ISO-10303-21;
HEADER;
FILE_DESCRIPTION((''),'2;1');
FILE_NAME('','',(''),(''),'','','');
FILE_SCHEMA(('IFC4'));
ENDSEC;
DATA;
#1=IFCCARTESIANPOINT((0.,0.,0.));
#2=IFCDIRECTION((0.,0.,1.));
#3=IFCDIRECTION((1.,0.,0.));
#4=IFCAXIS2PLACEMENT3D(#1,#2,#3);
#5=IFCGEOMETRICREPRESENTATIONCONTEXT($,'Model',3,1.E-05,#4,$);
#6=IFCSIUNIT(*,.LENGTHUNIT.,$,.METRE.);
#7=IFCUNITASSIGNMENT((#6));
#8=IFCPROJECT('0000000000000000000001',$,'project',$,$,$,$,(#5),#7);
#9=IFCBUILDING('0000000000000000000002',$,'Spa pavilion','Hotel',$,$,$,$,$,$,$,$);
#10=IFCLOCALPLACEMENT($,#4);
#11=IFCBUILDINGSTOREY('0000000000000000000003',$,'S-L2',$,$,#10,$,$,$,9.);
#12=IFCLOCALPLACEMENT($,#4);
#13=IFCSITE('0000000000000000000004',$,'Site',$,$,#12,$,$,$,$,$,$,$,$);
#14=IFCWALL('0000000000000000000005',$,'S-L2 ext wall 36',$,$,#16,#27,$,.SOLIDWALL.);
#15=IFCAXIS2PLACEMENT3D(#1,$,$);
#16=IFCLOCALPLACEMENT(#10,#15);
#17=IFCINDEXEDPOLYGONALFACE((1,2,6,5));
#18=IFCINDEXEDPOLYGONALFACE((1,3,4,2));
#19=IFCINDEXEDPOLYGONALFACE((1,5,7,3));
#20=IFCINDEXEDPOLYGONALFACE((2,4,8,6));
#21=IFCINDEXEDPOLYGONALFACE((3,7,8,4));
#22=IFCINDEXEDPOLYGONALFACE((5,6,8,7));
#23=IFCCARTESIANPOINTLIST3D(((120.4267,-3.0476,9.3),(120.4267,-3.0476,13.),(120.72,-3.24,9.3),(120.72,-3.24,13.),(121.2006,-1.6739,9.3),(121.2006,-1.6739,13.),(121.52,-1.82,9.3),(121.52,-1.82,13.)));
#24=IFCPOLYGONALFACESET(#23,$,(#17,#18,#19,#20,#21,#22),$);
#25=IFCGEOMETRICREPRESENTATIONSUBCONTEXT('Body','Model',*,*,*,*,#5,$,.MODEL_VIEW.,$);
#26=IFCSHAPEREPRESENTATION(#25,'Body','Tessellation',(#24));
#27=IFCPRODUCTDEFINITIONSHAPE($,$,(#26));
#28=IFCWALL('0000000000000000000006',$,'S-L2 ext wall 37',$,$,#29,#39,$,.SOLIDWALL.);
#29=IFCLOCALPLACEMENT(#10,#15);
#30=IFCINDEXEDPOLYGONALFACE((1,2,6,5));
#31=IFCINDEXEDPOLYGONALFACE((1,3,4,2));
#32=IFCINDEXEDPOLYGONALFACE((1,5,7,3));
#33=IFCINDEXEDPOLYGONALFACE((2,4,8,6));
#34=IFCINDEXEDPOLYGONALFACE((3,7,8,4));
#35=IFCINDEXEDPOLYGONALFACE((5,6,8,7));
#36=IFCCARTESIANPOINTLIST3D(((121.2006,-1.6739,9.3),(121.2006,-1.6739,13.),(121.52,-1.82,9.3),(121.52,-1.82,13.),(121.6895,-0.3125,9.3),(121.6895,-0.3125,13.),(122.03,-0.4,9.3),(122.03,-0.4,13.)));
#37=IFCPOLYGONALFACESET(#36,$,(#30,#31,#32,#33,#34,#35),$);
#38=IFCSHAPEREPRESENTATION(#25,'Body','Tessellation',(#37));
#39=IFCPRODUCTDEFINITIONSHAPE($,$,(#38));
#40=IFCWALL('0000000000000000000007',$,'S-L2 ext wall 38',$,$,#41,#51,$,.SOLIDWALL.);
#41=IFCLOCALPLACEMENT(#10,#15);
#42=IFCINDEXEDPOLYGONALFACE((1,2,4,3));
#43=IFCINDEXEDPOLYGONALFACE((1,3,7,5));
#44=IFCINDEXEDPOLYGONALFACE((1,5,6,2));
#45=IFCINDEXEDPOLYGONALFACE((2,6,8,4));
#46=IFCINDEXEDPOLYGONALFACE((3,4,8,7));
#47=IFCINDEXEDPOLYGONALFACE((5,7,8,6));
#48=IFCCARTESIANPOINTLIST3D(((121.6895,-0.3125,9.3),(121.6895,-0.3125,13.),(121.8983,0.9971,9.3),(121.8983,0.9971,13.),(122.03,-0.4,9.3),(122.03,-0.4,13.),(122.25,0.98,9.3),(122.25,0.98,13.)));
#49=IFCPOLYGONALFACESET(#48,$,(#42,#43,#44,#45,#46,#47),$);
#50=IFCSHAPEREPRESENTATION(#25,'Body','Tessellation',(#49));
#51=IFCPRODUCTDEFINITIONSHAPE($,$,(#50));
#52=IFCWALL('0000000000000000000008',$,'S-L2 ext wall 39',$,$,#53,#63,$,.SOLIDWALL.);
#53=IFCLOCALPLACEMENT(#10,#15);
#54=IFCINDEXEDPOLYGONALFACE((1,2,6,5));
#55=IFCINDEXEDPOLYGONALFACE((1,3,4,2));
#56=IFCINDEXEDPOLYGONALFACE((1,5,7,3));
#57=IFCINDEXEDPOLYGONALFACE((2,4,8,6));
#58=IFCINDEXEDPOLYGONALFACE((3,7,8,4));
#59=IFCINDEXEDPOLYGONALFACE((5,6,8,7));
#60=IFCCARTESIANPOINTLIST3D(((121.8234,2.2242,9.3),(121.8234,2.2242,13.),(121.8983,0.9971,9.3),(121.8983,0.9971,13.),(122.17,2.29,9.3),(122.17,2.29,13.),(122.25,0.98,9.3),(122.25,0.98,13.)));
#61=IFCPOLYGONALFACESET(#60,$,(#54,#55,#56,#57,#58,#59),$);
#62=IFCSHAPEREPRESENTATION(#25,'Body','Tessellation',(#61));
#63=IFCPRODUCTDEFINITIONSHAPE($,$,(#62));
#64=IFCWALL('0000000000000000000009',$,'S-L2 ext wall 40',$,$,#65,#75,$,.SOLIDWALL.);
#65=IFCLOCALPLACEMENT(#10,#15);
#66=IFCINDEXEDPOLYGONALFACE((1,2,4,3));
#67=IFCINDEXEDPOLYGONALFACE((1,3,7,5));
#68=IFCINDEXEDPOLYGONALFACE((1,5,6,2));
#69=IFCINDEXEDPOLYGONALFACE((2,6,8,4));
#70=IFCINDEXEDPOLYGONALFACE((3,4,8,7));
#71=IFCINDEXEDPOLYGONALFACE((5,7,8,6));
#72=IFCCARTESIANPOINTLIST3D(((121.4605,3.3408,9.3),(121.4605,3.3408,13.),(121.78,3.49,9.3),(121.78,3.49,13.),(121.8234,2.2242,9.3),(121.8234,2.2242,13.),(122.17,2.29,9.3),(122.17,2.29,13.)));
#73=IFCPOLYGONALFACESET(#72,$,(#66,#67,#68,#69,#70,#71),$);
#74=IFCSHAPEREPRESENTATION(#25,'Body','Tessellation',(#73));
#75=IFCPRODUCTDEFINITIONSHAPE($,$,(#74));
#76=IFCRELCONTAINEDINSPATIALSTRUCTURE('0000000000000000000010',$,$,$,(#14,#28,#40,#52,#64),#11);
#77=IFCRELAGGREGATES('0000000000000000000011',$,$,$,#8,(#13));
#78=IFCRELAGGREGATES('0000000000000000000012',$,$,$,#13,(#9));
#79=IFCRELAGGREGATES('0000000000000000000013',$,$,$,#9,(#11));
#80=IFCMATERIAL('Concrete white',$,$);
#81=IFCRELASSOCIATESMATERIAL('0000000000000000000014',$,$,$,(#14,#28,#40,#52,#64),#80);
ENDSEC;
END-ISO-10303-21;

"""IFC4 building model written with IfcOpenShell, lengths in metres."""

from ifc_helpers import new_model, si_unit, frame, origin_with_axes, place, context, subcontext, project, spatial, polyline, outline, extrude, material, element, save


model = new_model("IFC4")

# Units and contexts
model_context = context("Model", 3, precision=1e-05, world=origin_with_axes())
body_context = subcontext(model_context, "Body", "Model", "MODEL_VIEW")
ifc_project = project(units=[si_unit("LENGTHUNIT", "METRE")], contexts=[model_context])

# Site, building, storey
site_placement = place(None, origin_with_axes())
site = spatial("IfcSite", under=ifc_project, at=site_placement, Name="Site")
building = spatial("IfcBuilding", under=site, Name="Spa pavilion", Description="Hotel")
storey_placement = place(None, origin_with_axes())
storey = spatial("IfcBuildingStorey", under=building, at=storey_placement, Name="S-L2", Elevation=9.0)

# Walls
ifc_material_1 = material(Name="Concrete white")
wall_1_placement = place(storey_placement, origin_with_axes())
element("IfcWall", 1, at=wall_1_placement, inside=storey, material=ifc_material_1, Name="S-L2 ext wall 36", PredefinedType="SOLIDWALL", context=body_context, shape_type="SweptSolid", body=[
    extrude(outline(polyline([(120.72, -3.24), (121.52, -1.82), (121.2006, -1.6739), (120.4267, -3.0476), (120.72, -3.24)])), frame((0.0, 0.0, 9.3), z_axis=(0.0, 0.0, 1.0), x_axis=(1.0, 0.0, 0.0)), (0.0, 0.0, 1.0), 3.7),
])
wall_2_placement = place(storey_placement, origin_with_axes())
element("IfcWall", 2, at=wall_2_placement, inside=storey, material=ifc_material_1, Name="S-L2 ext wall 37", PredefinedType="SOLIDWALL", context=body_context, shape_type="SweptSolid", body=[
    extrude(outline(polyline([(121.52, -1.82), (122.03, -0.4), (121.6895, -0.3125), (121.2006, -1.6739), (121.52, -1.82)])), frame((0.0, 0.0, 9.3), z_axis=(0.0, 0.0, 1.0), x_axis=(1.0, 0.0, 0.0)), (0.0, 0.0, 1.0), 3.7),
])
wall_3_placement = place(storey_placement, origin_with_axes())
element("IfcWall", 3, at=wall_3_placement, inside=storey, material=ifc_material_1, Name="S-L2 ext wall 38", PredefinedType="SOLIDWALL", context=body_context, shape_type="SweptSolid", body=[
    extrude(outline(polyline([(122.03, -0.4), (122.25, 0.98), (121.8983, 0.9971), (121.6895, -0.3125), (122.03, -0.4)])), frame((0.0, 0.0, 9.3), z_axis=(0.0, 0.0, 1.0), x_axis=(1.0, 0.0, 0.0)), (0.0, 0.0, 1.0), 3.7),
])
wall_4_placement = place(storey_placement, origin_with_axes())
element("IfcWall", 4, at=wall_4_placement, inside=storey, material=ifc_material_1, Name="S-L2 ext wall 39", PredefinedType="SOLIDWALL", context=body_context, shape_type="SweptSolid", body=[
    extrude(outline(polyline([(122.25, 0.98), (122.17, 2.29), (121.8234, 2.2242), (121.8983, 0.9971), (122.25, 0.98)])), frame((0.0, 0.0, 9.3), z_axis=(0.0, 0.0, 1.0), x_axis=(1.0, 0.0, 0.0)), (0.0, 0.0, 1.0), 3.7),
])
wall_5_placement = place(storey_placement, origin_with_axes())
element("IfcWall", 5, at=wall_5_placement, inside=storey, material=ifc_material_1, Name="S-L2 ext wall 40", PredefinedType="SOLIDWALL", context=body_context, shape_type="SweptSolid", body=[
    extrude(outline(polyline([(122.17, 2.29), (121.78, 3.49), (121.4605, 3.3408), (121.8234, 2.2242), (122.17, 2.29)])), frame((0.0, 0.0, 9.3), z_axis=(0.0, 0.0, 1.0), x_axis=(1.0, 0.0, 0.0)), (0.0, 0.0, 1.0), 3.7),
])

save(model, "model.ifc")
